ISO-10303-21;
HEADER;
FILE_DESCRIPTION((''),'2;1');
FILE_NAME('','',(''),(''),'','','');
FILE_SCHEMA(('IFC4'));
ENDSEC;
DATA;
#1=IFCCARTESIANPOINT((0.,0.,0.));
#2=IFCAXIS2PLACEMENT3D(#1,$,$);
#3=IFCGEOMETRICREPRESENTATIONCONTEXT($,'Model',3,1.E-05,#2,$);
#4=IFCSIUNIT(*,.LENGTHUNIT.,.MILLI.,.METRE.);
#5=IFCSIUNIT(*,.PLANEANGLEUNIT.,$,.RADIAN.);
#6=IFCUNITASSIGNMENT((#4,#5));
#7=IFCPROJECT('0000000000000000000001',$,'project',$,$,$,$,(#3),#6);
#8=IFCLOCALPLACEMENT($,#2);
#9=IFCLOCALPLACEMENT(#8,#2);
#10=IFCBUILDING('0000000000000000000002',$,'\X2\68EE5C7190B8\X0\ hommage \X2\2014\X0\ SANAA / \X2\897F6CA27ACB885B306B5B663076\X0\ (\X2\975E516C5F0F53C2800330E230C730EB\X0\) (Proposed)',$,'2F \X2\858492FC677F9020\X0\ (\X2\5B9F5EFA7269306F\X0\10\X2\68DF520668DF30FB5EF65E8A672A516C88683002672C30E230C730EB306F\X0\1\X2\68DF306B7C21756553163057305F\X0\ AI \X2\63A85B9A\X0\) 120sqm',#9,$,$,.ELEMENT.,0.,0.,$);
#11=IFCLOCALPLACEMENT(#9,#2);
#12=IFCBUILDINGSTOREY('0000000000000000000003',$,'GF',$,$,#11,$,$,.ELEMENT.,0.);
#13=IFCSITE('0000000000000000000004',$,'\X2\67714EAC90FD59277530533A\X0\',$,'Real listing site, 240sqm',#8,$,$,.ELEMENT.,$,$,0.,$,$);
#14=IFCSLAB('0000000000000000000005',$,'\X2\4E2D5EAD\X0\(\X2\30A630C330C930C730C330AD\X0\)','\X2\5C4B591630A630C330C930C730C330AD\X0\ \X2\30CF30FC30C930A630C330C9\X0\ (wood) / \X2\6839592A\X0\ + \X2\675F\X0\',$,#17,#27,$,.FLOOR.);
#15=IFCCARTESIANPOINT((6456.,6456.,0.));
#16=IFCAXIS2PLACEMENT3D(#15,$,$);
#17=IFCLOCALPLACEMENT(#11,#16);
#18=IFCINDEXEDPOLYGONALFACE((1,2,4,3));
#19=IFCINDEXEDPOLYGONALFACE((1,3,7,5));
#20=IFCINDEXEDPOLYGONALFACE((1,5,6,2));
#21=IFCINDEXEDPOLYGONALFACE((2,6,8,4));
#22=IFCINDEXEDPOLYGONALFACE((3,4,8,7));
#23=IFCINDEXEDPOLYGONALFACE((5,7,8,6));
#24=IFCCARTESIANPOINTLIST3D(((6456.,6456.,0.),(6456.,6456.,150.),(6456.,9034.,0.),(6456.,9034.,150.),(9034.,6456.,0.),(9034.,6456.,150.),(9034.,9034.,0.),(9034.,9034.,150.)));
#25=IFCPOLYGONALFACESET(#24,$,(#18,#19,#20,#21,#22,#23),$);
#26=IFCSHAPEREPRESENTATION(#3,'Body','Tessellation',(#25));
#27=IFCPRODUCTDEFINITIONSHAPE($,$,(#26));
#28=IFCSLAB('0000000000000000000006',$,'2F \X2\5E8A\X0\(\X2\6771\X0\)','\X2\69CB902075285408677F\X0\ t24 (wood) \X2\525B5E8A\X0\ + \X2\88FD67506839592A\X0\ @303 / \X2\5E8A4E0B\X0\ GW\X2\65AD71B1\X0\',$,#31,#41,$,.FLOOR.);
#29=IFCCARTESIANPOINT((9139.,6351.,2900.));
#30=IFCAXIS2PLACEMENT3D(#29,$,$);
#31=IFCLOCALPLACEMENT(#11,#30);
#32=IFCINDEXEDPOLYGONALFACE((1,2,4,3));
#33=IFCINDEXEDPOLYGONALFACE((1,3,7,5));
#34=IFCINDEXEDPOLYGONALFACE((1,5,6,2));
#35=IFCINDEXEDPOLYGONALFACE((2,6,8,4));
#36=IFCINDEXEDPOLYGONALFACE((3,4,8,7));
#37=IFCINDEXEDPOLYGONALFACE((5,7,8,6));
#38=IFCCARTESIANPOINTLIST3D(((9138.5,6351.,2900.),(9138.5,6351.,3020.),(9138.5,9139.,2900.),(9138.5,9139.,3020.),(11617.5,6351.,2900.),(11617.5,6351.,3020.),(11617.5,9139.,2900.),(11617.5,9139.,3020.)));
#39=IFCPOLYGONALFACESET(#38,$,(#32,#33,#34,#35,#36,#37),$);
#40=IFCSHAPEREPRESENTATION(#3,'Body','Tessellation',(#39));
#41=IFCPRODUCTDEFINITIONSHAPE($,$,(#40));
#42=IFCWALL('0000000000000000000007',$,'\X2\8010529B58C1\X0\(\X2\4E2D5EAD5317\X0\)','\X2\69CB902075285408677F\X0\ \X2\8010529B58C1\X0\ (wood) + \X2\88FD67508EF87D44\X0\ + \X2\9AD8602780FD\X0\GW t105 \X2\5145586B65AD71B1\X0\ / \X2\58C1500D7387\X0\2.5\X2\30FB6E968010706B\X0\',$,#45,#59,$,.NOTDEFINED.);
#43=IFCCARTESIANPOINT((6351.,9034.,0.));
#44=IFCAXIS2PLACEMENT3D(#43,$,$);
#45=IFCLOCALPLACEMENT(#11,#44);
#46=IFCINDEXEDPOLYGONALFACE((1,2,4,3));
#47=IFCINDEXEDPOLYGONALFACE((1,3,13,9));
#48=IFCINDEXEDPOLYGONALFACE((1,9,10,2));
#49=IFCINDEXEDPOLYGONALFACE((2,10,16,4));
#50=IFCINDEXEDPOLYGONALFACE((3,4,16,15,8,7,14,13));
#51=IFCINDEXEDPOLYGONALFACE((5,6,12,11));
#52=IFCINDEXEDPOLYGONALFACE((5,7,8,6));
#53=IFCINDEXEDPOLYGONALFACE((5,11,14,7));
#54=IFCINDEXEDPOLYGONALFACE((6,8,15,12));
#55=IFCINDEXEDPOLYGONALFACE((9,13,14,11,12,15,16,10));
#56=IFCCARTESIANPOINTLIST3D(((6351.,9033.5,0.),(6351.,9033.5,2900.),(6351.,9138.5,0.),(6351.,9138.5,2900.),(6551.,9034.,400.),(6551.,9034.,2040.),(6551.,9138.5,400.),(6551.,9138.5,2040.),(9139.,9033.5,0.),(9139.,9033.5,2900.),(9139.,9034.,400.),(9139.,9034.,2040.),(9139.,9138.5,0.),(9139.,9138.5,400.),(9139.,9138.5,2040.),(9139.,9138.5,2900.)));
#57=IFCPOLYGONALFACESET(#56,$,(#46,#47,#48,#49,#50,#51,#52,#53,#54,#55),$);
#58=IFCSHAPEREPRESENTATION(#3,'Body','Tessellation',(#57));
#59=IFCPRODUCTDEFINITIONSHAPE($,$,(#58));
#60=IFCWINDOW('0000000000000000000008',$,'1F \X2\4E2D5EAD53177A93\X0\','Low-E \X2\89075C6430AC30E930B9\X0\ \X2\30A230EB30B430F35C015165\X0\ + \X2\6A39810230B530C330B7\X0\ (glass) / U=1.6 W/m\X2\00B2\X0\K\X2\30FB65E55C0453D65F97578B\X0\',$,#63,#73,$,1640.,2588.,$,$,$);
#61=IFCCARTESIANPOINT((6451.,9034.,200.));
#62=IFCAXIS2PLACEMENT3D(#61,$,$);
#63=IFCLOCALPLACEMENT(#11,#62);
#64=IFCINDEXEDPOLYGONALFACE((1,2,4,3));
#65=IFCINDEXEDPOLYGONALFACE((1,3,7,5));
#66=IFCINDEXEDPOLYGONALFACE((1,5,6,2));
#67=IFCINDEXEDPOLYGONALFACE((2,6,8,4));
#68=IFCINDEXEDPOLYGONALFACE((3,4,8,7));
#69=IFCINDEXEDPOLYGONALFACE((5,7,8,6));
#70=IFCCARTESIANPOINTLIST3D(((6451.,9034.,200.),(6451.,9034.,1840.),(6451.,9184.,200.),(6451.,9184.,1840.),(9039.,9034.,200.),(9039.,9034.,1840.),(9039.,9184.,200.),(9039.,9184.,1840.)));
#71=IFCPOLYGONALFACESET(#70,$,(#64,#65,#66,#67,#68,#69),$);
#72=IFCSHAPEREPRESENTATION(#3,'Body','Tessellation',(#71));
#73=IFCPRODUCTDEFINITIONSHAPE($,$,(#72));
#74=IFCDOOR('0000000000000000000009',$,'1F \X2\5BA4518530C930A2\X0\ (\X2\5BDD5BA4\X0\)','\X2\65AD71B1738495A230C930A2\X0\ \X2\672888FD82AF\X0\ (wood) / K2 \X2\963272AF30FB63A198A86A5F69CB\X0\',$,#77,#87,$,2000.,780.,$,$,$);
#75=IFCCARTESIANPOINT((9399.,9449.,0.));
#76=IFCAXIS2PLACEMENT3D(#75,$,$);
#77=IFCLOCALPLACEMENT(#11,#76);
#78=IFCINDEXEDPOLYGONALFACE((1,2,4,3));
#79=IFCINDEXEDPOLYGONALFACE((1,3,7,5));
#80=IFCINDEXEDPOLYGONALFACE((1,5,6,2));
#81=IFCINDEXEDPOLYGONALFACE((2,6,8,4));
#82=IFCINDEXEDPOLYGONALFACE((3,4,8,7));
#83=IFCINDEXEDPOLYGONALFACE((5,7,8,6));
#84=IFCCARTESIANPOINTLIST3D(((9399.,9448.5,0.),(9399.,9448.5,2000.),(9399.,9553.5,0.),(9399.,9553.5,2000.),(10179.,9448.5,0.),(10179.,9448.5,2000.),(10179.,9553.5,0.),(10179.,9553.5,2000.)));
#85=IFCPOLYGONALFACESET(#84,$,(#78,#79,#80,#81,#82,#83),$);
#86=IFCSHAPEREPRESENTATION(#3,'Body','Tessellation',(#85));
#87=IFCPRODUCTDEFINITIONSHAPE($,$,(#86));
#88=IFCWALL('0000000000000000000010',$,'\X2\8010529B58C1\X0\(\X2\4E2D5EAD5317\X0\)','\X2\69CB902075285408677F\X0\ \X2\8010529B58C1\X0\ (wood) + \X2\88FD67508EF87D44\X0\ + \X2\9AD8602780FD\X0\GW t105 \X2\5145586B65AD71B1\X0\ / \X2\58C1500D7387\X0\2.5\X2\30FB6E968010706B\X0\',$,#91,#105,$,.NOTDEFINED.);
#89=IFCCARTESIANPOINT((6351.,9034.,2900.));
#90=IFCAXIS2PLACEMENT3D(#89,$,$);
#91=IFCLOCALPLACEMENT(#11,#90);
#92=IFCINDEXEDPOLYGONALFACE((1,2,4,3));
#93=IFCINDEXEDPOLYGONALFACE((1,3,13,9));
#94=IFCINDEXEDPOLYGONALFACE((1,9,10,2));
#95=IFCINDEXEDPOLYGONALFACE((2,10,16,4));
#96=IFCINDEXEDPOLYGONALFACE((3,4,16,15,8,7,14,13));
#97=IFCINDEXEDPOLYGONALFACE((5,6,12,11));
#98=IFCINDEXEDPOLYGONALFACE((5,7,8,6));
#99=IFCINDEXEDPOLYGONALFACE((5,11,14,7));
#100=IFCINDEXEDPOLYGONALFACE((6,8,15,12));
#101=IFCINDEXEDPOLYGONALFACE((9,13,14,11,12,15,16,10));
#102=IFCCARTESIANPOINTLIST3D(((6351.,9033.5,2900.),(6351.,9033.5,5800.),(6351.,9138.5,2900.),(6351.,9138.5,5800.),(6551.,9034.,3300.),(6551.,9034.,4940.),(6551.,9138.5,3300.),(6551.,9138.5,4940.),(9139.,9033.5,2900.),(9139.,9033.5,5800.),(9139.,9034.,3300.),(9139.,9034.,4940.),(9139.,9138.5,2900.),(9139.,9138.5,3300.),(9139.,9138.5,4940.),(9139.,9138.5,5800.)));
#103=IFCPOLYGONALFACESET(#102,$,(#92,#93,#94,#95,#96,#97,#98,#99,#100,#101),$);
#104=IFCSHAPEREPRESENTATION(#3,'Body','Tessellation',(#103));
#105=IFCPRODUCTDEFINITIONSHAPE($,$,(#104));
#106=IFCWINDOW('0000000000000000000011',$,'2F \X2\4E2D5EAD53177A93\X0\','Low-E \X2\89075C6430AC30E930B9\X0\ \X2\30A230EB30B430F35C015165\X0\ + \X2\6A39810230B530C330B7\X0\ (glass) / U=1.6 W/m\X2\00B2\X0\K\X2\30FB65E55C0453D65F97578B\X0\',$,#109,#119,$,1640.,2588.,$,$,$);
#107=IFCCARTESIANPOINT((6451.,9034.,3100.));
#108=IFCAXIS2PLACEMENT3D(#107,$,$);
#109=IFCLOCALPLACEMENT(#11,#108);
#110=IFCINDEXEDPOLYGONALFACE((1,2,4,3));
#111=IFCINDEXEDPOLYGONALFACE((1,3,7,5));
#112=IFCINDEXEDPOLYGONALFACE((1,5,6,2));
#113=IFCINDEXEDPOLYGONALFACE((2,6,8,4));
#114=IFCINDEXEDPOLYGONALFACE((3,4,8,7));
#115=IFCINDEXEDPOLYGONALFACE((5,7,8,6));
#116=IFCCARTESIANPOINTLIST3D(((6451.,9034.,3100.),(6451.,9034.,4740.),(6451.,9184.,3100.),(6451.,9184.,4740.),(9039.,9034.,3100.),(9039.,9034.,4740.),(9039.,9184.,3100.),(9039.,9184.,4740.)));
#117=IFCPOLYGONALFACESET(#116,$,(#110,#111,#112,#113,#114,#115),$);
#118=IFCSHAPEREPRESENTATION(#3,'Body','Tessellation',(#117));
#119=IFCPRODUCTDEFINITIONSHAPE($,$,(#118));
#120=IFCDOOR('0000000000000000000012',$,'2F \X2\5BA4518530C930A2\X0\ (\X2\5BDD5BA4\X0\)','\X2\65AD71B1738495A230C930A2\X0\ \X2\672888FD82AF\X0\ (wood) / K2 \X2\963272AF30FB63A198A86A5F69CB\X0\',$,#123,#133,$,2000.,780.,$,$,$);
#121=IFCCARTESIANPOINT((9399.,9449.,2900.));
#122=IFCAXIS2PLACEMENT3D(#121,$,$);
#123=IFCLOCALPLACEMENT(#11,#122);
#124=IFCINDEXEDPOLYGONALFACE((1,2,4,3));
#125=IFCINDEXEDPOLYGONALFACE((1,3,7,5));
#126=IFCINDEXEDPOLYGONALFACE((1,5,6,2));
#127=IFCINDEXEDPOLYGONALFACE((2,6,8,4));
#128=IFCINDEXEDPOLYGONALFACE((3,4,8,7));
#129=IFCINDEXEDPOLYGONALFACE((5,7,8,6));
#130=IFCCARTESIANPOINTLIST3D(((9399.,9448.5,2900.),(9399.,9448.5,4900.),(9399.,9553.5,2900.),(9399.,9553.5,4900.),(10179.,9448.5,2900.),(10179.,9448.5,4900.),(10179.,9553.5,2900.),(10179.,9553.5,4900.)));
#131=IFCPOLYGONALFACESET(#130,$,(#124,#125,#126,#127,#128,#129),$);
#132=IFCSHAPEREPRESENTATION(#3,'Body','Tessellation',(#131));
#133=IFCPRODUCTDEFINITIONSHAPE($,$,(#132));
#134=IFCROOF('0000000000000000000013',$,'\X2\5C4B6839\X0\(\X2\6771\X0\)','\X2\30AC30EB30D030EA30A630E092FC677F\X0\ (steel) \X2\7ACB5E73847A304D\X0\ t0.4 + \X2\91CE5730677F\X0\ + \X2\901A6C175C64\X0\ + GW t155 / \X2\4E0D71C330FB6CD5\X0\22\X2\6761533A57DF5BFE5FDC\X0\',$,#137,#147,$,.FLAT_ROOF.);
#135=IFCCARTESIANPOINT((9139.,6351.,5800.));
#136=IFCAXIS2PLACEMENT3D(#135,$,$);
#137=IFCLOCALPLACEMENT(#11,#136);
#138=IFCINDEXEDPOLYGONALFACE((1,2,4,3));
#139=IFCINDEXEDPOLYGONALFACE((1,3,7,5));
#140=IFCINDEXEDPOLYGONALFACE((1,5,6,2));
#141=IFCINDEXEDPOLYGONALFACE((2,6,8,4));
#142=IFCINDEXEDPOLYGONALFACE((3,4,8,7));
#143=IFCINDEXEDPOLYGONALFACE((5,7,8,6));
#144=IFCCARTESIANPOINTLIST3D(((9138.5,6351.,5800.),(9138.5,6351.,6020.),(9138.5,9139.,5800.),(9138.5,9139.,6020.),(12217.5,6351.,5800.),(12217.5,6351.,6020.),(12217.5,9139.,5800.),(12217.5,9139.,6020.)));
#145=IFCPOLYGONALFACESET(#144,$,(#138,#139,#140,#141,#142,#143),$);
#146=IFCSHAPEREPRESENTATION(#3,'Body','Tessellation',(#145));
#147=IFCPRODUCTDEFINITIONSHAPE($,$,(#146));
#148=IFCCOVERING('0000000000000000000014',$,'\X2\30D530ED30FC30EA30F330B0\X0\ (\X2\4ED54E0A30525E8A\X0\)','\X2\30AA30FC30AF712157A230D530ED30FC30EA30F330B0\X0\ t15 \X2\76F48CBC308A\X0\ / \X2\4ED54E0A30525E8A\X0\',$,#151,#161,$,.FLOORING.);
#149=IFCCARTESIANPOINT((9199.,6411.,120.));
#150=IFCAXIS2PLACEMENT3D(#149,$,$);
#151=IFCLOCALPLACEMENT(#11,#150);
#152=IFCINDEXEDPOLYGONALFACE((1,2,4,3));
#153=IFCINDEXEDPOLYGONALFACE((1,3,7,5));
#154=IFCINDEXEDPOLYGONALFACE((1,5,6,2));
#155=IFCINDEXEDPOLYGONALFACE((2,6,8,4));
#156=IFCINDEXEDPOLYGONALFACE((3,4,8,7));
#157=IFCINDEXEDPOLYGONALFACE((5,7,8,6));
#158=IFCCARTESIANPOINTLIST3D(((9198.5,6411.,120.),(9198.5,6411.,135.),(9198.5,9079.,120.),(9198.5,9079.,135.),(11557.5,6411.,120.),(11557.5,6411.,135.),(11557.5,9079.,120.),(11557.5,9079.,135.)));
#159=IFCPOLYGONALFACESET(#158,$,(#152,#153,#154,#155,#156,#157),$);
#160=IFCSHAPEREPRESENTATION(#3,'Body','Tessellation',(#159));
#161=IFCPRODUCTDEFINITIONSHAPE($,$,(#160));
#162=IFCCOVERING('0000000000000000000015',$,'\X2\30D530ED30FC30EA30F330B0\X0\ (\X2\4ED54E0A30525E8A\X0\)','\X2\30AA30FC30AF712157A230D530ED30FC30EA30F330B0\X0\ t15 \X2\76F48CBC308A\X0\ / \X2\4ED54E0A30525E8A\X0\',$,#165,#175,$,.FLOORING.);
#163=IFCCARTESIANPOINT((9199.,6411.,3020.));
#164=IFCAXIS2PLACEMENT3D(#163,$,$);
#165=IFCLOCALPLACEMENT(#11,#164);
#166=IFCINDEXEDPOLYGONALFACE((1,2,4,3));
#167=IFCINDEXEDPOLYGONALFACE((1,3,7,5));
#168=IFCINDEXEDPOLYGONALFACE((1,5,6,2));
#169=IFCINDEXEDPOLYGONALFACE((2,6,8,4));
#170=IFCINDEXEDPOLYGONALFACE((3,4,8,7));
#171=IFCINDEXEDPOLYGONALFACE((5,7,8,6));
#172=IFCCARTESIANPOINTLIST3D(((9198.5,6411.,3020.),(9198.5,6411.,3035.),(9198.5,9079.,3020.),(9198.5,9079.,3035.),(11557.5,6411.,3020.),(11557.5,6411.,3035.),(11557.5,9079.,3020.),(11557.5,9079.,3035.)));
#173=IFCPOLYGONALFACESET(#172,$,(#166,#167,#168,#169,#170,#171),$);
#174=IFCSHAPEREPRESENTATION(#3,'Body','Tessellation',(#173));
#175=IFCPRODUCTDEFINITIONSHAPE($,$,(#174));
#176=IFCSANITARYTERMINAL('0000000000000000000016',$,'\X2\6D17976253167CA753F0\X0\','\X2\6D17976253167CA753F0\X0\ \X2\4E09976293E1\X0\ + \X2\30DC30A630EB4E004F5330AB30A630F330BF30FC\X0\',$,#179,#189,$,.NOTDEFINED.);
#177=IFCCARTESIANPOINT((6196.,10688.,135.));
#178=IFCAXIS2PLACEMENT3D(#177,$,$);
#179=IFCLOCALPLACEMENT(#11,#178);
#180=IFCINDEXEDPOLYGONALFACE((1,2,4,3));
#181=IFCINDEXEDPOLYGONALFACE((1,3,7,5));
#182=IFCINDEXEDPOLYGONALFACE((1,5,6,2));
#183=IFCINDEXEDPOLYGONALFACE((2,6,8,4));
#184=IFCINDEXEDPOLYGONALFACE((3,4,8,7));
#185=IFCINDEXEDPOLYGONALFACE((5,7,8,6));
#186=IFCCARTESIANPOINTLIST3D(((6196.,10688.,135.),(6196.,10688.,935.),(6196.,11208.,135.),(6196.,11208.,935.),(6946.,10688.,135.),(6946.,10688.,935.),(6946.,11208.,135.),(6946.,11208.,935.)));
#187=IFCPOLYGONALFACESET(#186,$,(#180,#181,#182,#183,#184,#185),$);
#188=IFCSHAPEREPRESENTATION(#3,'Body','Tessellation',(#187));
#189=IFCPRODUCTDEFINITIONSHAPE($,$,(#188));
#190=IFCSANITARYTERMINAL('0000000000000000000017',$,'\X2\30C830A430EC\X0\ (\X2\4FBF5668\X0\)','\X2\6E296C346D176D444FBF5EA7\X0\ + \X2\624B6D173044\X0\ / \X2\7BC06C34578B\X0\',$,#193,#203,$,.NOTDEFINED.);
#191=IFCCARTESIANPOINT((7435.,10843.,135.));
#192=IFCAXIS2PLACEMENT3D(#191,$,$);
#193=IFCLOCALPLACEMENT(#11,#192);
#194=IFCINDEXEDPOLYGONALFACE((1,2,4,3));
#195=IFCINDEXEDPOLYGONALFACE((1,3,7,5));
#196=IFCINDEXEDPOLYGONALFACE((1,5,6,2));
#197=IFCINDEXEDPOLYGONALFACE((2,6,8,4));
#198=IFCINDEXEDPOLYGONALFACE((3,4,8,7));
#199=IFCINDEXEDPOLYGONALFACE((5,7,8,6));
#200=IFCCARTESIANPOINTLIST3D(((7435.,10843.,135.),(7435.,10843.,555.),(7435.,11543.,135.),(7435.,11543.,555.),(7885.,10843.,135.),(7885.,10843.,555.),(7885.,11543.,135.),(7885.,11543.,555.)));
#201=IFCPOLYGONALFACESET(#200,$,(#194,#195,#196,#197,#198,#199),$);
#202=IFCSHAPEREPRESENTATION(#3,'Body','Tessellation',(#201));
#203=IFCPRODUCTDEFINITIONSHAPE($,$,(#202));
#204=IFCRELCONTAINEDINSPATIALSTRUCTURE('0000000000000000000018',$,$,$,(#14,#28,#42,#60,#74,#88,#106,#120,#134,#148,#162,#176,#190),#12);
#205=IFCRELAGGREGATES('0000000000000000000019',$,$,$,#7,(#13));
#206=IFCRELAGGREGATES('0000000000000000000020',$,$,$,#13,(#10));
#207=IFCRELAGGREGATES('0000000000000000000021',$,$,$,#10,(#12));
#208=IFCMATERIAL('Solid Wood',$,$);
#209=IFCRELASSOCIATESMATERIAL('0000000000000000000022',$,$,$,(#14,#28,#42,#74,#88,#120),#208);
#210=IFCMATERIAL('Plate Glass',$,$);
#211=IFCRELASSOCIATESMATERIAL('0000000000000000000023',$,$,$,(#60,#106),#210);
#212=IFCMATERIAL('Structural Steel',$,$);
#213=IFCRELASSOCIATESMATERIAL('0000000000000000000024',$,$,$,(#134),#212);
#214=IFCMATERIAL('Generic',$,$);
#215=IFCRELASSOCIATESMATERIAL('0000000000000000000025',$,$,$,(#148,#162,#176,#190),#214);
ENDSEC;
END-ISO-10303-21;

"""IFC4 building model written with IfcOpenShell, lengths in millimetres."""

from ifc_helpers import new_model, si_unit, frame, frame_2d, origin, place, context, project, spatial, rectangle, extrude, material, element, fill, save


model = new_model("IFC4")

# Units and contexts
model_context = context("Model", 3, precision=1e-05, world=origin())
ifc_project = project(units=[si_unit("LENGTHUNIT", "METRE", prefix="MILLI"), si_unit("PLANEANGLEUNIT", "RADIAN")], contexts=[model_context])

# Site, building, storey
site_placement = place(None, origin())
site = spatial("IfcSite", under=ifc_project, at=site_placement, Name="東京都大田区", ObjectType="Real listing site, 240sqm", CompositionType="ELEMENT", RefElevation=0.0)
building_placement = place(site_placement, origin())
building = spatial("IfcBuilding", under=site, at=building_placement, Name="森山邸 hommage — SANAA / 西沢立衛に学ぶ (非公式参考モデル) (Proposed)", ObjectType="2F 薄鋼板造 (実建物は10棟分棟・延床未公表。本モデルは1棟に簡略化した AI 推定) 120sqm", CompositionType="ELEMENT", ElevationOfRefHeight=0.0, ElevationOfTerrain=0.0)
storey_placement = place(building_placement, origin())
storey = spatial("IfcBuildingStorey", under=building, at=storey_placement, Name="GF", CompositionType="ELEMENT", Elevation=0.0)

# Slabs
ifc_material_1 = material(Name="Solid Wood")
slab_1_placement = place(storey_placement, frame((6456.0, 6456.0, 0.0)))
element("IfcSlab", 1, at=slab_1_placement, inside=storey, material=ifc_material_1, Name="中庭(ウッドデッキ)", Description="屋外ウッドデッキ ハードウッド (wood) / 根太 + 束", PredefinedType="FLOOR", context=model_context, shape_type="SweptSolid", body=[
    extrude(rectangle(XDim=2578.0, YDim=2578.0, at=frame_2d((1289.0, 1289.0))), frame((6456.0, 6456.0, 0.0)), (0.0, 0.0, 1.0), 150.0),
])
slab_2_placement = place(storey_placement, frame((9139.0, 6351.0, 2900.0)))
element("IfcSlab", 2, at=slab_2_placement, inside=storey, material=ifc_material_1, Name="2F 床(東)", Description="構造用合板 t24 (wood) 剛床 + 製材根太 @303 / 床下 GW断熱", PredefinedType="FLOOR", context=model_context, shape_type="SweptSolid", body=[
    extrude(rectangle(XDim=2479.0, YDim=2788.0, at=frame_2d((1239.0, 1394.0))), frame((9139.0, 6351.0, 2900.0)), (0.0, 0.0, 1.0), 120.0),
])

# Wall, opening, window
wall_1_placement = place(storey_placement, frame((6351.0, 9034.0, 0.0)))
wall_1 = element("IfcWall", 3, at=wall_1_placement, inside=storey, material=ifc_material_1, Name="耐力壁(中庭北)", Description="構造用合板 耐力壁 (wood) + 製材軸組 + 高性能GW t105 充填断熱 / 壁倍率2.5・準耐火", PredefinedType="NOTDEFINED", context=model_context, shape_type="SweptSolid", body=[
    extrude(rectangle(XDim=2788.0, YDim=105.0, at=frame_2d((1394.0, 52.0))), frame((6351.0, 9034.0, 0.0)), (0.0, 0.0, 1.0), 2900.0),
])
opening_1_placement = place(storey_placement, frame((6451.0, 9034.0, 200.0)))
opening_1 = element("IfcOpeningElement", 4, at=opening_1_placement, cuts=wall_1, PredefinedType="NOTDEFINED", context=model_context, shape_type="SweptSolid", body=[
    extrude(rectangle(XDim=2588.0, YDim=150.0, at=frame_2d((1294.0, 75.0))), frame((6451.0, 9034.0, 200.0)), (0.0, 0.0, 1.0), 1640.0),
])
ifc_material_2 = material(Name="Plate Glass")
window_1_placement = place(storey_placement, frame((6451.0, 9034.0, 200.0)))
window_1 = element("IfcWindow", 5, at=window_1_placement, inside=storey, material=ifc_material_2, Name="1F 中庭北窓", Description="Low-E 複層ガラス アルゴン封入 + 樹脂サッシ (glass) / U=1.6 W/m²K・日射取得型", OverallHeight=1640.0, OverallWidth=2588.0, context=model_context, shape_type="SweptSolid", body=[
    extrude(rectangle(XDim=2588.0, YDim=150.0, at=frame_2d((1294.0, 75.0))), frame((6451.0, 9034.0, 200.0)), (0.0, 0.0, 1.0), 1640.0),
])
fill(opening_1, window_1)

# Door
door_1_placement = place(storey_placement, frame((9399.0, 9449.0, 0.0)))
element("IfcDoor", 6, at=door_1_placement, inside=storey, material=ifc_material_1, Name="1F 室内ドア (寝室)", Description="断熱玄関ドア 木製芯 (wood) / K2 防犯・採風機構", OverallHeight=2000.0, OverallWidth=780.0, context=model_context, shape_type="SweptSolid", body=[
    extrude(rectangle(XDim=780.0, YDim=105.0, at=frame_2d((390.0, 52.0))), frame((9399.0, 9449.0, 0.0)), (0.0, 0.0, 1.0), 2000.0),
])

# Wall, opening, window
wall_2_placement = place(storey_placement, frame((6351.0, 9034.0, 2900.0)))
wall_2 = element("IfcWall", 7, at=wall_2_placement, inside=storey, material=ifc_material_1, Name="耐力壁(中庭北)", Description="構造用合板 耐力壁 (wood) + 製材軸組 + 高性能GW t105 充填断熱 / 壁倍率2.5・準耐火", PredefinedType="NOTDEFINED", context=model_context, shape_type="SweptSolid", body=[
    extrude(rectangle(XDim=2788.0, YDim=105.0, at=frame_2d((1394.0, 52.0))), frame((6351.0, 9034.0, 2900.0)), (0.0, 0.0, 1.0), 2900.0),
])
opening_2_placement = place(storey_placement, frame((6451.0, 9034.0, 3100.0)))
opening_2 = element("IfcOpeningElement", 8, at=opening_2_placement, cuts=wall_2, PredefinedType="NOTDEFINED", context=model_context, shape_type="SweptSolid", body=[
    extrude(rectangle(XDim=2588.0, YDim=150.0, at=frame_2d((1294.0, 75.0))), frame((6451.0, 9034.0, 3100.0)), (0.0, 0.0, 1.0), 1640.0),
])
window_2_placement = place(storey_placement, frame((6451.0, 9034.0, 3100.0)))
window_2 = element("IfcWindow", 9, at=window_2_placement, inside=storey, material=ifc_material_2, Name="2F 中庭北窓", Description="Low-E 複層ガラス アルゴン封入 + 樹脂サッシ (glass) / U=1.6 W/m²K・日射取得型", OverallHeight=1640.0, OverallWidth=2588.0, context=model_context, shape_type="SweptSolid", body=[
    extrude(rectangle(XDim=2588.0, YDim=150.0, at=frame_2d((1294.0, 75.0))), frame((6451.0, 9034.0, 3100.0)), (0.0, 0.0, 1.0), 1640.0),
])
fill(opening_2, window_2)

# Door
door_2_placement = place(storey_placement, frame((9399.0, 9449.0, 2900.0)))
element("IfcDoor", 10, at=door_2_placement, inside=storey, material=ifc_material_1, Name="2F 室内ドア (寝室)", Description="断熱玄関ドア 木製芯 (wood) / K2 防犯・採風機構", OverallHeight=2000.0, OverallWidth=780.0, context=model_context, shape_type="SweptSolid", body=[
    extrude(rectangle(XDim=780.0, YDim=105.0, at=frame_2d((390.0, 52.0))), frame((9399.0, 9449.0, 2900.0)), (0.0, 0.0, 1.0), 2000.0),
])

# Roof
ifc_material_3 = material(Name="Structural Steel")
for number, where, name in (
    (11, (9139.0, 6351.0, 5800.0), "屋根(東)"),
):
    element("IfcRoof", number, at=place(storey_placement, frame(where)), inside=storey, material=ifc_material_3, Name=name, Description="ガルバリウム鋼板 (steel) 立平葺き t0.4 + 野地板 + 通気層 + GW t155 / 不燃・法22条区域対応", PredefinedType="FLAT_ROOF", context=model_context, shape_type="SweptSolid", body=[
        extrude(rectangle(XDim=3079.0, YDim=2788.0, at=frame_2d((1539.0, 1394.0))), frame((9139.0, 6351.0, 5800.0)), (0.0, 0.0, 1.0), 220.0),
    ])

# Coverings
ifc_material_4 = material(Name="Generic")
covering_1_placement = place(storey_placement, frame((9199.0, 6411.0, 120.0)))
element("IfcCovering", 12, at=covering_1_placement, inside=storey, material=ifc_material_4, Name="フローリング (仕上げ床)", Description="オーク無垢フローリング t15 直貼り / 仕上げ床", PredefinedType="FLOORING", context=model_context, shape_type="SweptSolid", body=[
    extrude(rectangle(XDim=2359.0, YDim=2668.0, at=frame_2d((1179.0, 1334.0))), frame((9199.0, 6411.0, 120.0)), (0.0, 0.0, 1.0), 15.0),
])
covering_2_placement = place(storey_placement, frame((9199.0, 6411.0, 3020.0)))
element("IfcCovering", 13, at=covering_2_placement, inside=storey, material=ifc_material_4, Name="フローリング (仕上げ床)", Description="オーク無垢フローリング t15 直貼り / 仕上げ床", PredefinedType="FLOORING", context=model_context, shape_type="SweptSolid", body=[
    extrude(rectangle(XDim=2359.0, YDim=2668.0, at=frame_2d((1179.0, 1334.0))), frame((9199.0, 6411.0, 3020.0)), (0.0, 0.0, 1.0), 15.0),
])

# Sanitary terminals
sanitary_terminal_1_placement = place(storey_placement, frame((6196.0, 10688.0, 135.0)))
element("IfcSanitaryTerminal", 14, at=sanitary_terminal_1_placement, inside=storey, material=ifc_material_4, Name="洗面化粧台", Description="洗面化粧台 三面鏡 + ボウル一体カウンター", PredefinedType="NOTDEFINED", context=model_context, shape_type="SweptSolid", body=[
    extrude(rectangle(XDim=750.0, YDim=520.0, at=frame_2d((375.0, 260.0))), frame((6196.0, 10688.0, 135.0)), (0.0, 0.0, 1.0), 800.0),
])
sanitary_terminal_2_placement = place(storey_placement, frame((7435.0, 10843.0, 135.0)))
element("IfcSanitaryTerminal", 15, at=sanitary_terminal_2_placement, inside=storey, material=ifc_material_4, Name="トイレ (便器)", Description="温水洗浄便座 + 手洗い / 節水型", PredefinedType="NOTDEFINED", context=model_context, shape_type="SweptSolid", body=[
    extrude(rectangle(XDim=450.0, YDim=700.0, at=frame_2d((225.0, 350.0))), frame((7435.0, 10843.0, 135.0)), (0.0, 0.0, 1.0), 420.0),
])

save(model, "model.ifc")
